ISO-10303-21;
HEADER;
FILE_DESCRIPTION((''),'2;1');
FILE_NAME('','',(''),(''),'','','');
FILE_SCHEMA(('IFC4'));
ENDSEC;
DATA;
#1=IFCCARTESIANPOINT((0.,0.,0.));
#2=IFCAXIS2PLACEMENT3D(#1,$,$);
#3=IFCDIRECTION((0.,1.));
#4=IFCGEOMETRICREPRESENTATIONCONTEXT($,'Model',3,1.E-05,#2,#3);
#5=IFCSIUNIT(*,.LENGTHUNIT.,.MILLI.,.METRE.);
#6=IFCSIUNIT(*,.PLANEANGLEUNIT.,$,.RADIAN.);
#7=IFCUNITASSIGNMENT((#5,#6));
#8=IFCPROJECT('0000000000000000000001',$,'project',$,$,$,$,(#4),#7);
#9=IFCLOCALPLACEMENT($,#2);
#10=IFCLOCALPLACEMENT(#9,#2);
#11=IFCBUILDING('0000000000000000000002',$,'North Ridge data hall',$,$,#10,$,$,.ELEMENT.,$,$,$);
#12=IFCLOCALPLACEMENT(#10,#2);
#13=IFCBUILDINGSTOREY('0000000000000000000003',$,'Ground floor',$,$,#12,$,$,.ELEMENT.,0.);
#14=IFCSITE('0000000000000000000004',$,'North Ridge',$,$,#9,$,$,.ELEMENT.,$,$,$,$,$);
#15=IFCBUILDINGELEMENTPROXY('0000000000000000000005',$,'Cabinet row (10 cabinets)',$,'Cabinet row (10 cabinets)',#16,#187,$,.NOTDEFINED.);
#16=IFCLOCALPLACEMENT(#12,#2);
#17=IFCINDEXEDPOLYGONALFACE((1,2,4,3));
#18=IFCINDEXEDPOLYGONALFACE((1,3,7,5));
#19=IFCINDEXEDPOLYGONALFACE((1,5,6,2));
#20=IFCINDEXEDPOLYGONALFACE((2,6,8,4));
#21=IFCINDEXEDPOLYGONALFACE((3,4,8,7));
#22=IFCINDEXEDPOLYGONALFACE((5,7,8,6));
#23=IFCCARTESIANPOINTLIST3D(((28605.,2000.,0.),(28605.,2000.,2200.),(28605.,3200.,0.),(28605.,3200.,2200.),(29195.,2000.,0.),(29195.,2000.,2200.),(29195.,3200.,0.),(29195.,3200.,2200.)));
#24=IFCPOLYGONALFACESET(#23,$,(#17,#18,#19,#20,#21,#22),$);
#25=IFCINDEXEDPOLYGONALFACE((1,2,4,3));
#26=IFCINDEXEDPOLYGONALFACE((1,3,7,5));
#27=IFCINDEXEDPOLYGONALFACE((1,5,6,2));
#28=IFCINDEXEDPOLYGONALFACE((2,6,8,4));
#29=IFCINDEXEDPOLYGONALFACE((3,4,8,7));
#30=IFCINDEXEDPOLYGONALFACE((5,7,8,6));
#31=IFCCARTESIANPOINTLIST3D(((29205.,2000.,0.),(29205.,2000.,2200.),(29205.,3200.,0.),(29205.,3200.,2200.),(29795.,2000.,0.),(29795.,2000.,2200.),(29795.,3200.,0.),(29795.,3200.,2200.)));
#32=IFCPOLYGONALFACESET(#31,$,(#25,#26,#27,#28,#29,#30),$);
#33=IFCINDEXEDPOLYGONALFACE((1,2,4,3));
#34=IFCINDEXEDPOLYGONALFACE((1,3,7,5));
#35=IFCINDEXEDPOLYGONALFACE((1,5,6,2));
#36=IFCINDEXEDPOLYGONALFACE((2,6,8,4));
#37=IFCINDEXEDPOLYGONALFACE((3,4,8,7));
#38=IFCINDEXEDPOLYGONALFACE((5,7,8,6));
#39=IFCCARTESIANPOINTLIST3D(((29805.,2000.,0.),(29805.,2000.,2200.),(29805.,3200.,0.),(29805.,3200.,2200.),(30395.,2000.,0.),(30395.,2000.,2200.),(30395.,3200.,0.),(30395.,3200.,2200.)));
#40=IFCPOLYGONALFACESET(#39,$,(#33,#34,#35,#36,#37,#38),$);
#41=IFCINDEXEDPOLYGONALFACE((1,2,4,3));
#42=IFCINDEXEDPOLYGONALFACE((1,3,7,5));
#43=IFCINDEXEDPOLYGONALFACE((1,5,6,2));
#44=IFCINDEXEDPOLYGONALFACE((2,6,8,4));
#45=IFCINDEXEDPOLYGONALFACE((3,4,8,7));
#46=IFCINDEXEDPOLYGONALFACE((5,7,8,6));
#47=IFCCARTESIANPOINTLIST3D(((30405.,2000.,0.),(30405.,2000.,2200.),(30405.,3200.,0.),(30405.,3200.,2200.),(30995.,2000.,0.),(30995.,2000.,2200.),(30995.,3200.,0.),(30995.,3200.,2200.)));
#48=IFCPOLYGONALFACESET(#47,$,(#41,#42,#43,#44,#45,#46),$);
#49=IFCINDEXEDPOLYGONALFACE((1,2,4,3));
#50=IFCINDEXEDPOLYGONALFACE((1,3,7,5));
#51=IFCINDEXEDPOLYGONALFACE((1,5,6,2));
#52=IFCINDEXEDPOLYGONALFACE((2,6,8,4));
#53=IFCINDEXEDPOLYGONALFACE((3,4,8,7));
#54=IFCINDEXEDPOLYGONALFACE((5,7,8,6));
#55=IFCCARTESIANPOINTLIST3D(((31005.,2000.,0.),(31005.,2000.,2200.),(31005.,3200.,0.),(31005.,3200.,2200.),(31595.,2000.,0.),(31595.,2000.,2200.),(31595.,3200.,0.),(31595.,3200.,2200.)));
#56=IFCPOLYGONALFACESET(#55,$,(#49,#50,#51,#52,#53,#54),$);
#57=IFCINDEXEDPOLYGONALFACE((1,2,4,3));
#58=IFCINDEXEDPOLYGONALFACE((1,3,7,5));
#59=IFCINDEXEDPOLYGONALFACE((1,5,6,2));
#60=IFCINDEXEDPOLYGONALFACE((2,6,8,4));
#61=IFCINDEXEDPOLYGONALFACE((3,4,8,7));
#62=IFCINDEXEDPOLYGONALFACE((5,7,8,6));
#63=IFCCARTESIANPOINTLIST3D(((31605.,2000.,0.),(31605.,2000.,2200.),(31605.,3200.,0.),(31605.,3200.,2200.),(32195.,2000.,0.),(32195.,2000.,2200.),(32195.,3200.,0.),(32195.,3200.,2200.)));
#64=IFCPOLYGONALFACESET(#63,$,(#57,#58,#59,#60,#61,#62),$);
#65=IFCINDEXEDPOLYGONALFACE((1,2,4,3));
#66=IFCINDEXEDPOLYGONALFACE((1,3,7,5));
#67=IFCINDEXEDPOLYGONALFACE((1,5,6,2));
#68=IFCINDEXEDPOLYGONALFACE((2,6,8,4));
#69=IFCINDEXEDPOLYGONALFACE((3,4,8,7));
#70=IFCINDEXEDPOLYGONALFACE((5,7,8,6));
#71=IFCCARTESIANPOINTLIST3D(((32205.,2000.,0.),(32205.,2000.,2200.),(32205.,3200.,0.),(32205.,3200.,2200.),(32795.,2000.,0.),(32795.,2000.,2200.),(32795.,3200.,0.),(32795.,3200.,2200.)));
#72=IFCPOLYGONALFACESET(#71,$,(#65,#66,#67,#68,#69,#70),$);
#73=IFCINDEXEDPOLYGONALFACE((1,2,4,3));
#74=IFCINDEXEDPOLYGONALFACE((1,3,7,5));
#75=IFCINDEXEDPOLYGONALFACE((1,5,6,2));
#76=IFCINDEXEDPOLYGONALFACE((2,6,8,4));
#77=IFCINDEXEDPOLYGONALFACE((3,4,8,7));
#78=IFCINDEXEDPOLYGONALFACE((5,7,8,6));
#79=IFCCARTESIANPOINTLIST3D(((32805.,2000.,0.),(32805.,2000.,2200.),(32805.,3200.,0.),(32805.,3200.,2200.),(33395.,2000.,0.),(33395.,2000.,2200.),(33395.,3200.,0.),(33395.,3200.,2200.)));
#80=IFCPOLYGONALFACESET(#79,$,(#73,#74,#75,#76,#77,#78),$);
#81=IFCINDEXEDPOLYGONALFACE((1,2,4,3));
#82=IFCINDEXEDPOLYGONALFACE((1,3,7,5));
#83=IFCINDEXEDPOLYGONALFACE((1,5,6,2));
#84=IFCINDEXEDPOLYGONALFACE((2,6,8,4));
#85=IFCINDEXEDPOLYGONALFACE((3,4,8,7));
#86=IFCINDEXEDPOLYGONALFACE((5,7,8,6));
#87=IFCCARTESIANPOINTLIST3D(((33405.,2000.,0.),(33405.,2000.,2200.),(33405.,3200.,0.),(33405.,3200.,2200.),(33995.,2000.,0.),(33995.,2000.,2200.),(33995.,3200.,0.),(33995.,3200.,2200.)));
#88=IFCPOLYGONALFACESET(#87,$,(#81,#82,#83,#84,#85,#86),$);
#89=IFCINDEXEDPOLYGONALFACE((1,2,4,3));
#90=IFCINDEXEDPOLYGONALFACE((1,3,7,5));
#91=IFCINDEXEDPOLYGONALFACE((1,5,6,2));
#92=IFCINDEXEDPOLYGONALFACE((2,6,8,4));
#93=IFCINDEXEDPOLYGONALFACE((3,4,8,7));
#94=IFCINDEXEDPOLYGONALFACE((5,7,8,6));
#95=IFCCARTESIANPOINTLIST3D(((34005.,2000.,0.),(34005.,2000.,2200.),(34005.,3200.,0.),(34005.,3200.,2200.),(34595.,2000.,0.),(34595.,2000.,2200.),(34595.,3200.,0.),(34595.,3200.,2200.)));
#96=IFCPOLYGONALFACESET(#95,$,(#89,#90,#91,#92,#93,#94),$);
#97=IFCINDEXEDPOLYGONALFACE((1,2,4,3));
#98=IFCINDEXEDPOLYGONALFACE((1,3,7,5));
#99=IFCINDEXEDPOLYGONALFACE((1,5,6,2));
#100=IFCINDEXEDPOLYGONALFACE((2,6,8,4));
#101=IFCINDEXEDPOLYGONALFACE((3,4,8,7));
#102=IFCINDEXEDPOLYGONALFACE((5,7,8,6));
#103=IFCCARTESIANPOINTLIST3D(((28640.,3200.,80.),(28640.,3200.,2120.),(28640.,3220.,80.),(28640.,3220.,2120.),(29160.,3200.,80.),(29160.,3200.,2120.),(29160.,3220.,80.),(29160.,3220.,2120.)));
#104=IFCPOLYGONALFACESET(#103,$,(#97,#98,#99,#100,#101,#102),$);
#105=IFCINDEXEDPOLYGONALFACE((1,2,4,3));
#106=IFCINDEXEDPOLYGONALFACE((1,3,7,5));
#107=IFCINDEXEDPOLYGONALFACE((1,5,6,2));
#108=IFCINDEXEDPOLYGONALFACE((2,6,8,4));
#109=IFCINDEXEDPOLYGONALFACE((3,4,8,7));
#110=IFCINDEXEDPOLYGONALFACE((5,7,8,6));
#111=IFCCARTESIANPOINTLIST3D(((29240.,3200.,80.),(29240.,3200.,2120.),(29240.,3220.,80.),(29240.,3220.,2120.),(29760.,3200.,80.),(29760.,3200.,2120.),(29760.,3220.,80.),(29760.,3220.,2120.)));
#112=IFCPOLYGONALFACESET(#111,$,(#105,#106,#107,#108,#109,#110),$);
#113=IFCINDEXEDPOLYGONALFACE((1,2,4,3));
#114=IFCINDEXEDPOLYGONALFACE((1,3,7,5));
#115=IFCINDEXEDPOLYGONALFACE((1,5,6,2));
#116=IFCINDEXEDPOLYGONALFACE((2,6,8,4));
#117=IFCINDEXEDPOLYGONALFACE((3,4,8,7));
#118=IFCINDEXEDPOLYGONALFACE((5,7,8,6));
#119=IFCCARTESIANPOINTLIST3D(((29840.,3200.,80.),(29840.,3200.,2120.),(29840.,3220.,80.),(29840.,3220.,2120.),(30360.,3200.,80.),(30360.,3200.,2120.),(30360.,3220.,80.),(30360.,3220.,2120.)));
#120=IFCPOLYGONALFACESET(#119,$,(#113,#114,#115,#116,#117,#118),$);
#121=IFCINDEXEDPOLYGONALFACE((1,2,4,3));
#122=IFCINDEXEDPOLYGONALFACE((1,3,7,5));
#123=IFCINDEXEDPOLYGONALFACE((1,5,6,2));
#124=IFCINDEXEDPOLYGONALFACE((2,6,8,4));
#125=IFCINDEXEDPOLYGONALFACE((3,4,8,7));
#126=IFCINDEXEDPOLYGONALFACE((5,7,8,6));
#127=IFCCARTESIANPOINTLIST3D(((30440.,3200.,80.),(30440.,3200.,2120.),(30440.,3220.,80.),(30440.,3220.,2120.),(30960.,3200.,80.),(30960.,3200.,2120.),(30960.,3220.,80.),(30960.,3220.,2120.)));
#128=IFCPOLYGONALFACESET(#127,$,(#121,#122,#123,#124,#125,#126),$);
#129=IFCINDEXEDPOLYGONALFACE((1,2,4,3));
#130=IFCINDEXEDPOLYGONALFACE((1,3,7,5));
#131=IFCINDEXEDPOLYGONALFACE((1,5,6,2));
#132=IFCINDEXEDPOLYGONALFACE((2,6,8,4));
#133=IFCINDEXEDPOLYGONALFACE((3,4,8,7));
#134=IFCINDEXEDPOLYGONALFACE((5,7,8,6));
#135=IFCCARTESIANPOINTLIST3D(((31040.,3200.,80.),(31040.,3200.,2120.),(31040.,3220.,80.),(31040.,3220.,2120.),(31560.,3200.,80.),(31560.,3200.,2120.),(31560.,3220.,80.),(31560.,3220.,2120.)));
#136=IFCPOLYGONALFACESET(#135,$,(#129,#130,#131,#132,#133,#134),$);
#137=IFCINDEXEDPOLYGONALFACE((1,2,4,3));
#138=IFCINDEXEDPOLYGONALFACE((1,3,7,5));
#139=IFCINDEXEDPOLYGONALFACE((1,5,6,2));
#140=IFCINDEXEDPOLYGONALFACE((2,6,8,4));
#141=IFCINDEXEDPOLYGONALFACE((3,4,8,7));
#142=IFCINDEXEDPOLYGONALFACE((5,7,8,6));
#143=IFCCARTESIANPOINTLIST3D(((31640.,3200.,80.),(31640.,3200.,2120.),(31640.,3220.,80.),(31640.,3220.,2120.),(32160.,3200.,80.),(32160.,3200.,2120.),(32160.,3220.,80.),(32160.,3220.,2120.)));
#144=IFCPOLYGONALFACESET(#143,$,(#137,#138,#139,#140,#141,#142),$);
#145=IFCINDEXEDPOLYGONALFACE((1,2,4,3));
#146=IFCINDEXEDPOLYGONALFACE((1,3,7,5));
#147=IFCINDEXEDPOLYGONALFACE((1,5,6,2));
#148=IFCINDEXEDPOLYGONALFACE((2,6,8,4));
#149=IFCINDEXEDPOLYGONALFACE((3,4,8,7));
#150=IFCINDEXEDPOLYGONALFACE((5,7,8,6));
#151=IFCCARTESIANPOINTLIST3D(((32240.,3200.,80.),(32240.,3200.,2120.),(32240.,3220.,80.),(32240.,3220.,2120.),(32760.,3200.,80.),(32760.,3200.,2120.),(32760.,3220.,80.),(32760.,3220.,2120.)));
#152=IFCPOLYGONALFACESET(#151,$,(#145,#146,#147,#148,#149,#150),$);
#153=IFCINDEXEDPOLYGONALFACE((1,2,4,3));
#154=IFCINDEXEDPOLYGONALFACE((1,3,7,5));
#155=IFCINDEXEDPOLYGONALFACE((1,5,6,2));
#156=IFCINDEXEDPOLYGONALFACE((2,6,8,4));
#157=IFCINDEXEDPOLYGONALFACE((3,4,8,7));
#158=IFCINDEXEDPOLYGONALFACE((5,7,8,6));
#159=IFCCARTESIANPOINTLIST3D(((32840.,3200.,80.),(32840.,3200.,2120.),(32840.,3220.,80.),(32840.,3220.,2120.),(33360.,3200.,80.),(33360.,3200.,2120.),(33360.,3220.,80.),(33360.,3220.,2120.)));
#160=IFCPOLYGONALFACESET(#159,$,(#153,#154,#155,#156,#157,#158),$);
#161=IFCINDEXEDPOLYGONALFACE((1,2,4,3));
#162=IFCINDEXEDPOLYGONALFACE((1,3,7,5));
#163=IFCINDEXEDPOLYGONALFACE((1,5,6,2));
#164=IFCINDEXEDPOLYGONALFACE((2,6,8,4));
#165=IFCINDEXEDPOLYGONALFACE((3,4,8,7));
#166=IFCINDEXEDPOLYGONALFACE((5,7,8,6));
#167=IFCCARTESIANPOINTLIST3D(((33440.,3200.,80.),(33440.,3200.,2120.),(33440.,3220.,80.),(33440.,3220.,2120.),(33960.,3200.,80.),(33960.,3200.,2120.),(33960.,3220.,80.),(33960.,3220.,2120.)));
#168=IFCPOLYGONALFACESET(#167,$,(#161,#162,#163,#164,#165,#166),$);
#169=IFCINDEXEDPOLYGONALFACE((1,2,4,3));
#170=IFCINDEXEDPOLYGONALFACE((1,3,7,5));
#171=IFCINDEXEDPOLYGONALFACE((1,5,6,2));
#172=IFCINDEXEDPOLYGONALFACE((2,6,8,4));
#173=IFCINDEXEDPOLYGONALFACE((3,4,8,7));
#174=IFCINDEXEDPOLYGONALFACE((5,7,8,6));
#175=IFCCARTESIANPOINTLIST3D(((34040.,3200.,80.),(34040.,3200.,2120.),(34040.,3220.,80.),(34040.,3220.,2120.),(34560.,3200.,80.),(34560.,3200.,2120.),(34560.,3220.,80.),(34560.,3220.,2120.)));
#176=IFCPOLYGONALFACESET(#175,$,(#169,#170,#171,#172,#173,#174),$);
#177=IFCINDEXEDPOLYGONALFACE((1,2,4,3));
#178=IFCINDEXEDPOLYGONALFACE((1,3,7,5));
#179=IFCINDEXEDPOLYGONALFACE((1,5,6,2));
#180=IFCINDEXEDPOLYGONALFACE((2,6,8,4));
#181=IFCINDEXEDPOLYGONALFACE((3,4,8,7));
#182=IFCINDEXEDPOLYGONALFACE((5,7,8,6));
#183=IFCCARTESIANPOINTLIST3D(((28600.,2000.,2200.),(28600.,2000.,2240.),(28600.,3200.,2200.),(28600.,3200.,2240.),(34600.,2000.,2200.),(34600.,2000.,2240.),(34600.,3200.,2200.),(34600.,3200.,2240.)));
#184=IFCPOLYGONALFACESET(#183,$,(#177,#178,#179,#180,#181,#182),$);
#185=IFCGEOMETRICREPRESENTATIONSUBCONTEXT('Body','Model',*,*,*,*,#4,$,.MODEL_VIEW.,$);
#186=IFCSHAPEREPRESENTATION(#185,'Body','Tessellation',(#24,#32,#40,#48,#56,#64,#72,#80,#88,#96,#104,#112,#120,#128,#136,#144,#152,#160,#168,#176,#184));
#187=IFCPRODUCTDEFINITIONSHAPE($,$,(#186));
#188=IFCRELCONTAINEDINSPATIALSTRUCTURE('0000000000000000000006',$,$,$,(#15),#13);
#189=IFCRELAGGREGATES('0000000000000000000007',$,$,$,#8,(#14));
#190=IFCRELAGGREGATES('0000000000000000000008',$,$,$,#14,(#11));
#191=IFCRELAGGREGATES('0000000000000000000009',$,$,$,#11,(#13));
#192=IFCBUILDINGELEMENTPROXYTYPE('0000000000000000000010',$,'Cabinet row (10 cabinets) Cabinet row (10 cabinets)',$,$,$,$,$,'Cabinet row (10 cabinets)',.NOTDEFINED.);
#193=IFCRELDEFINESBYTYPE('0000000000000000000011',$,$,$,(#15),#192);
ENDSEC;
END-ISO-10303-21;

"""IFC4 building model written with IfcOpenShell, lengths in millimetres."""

from ifc_helpers import new_model, si_unit, direction, frame, origin, place, context, subcontext, project, spatial, polyline, outline, extrude, source, transform, mapped, type_object, type_shapes, element, save


model = new_model("IFC4")

# Units and contexts
model_context = context("Model", 3, precision=1e-05, world=origin(), true_north=direction((0.0, 1.0)))
body_context = subcontext(model_context, "Body", "Model", "MODEL_VIEW")
ifc_project = project(units=[si_unit("LENGTHUNIT", "METRE", prefix="MILLI"), si_unit("PLANEANGLEUNIT", "RADIAN")], contexts=[model_context])

# Site, building, storey
site_placement = place(None, origin())
site = spatial("IfcSite", under=ifc_project, at=site_placement, Name="North Ridge", CompositionType="ELEMENT")
building_placement = place(site_placement, origin())
building = spatial("IfcBuilding", under=site, at=building_placement, Name="North Ridge data hall", CompositionType="ELEMENT")
storey_placement = place(building_placement, origin())
storey = spatial("IfcBuildingStorey", under=building, at=storey_placement, Name="Ground floor", CompositionType="ELEMENT", Elevation=0.0)

# Building element proxy
building_element_proxy_type_1 = type_object("IfcBuildingElementProxyType", Name="Cabinet row (10 cabinets) Cabinet row (10 cabinets)", ElementType="Cabinet row (10 cabinets)", PredefinedType="NOTDEFINED")
shared_shape_1 = source(origin(), body_context, "Body", "SweptSolid", [
    extrude(outline(polyline([(5.0, 0.0), (595.0, 0.0), (595.0, 1200.0), (5.0, 1200.0), (5.0, 0.0)])), origin(), (0.0, 0.0, 1.0), 2200.0),
    extrude(outline(polyline([(605.0, 0.0), (1195.0, 0.0), (1195.0, 1200.0), (605.0, 1200.0), (605.0, 0.0)])), origin(), (0.0, 0.0, 1.0), 2200.0),
    extrude(outline(polyline([(1205.0, 0.0), (1795.0, 0.0), (1795.0, 1200.0), (1205.0, 1200.0), (1205.0, 0.0)])), origin(), (0.0, 0.0, 1.0), 2200.0),
    extrude(outline(polyline([(1805.0, 0.0), (2395.0, 0.0), (2395.0, 1200.0), (1805.0, 1200.0), (1805.0, 0.0)])), origin(), (0.0, 0.0, 1.0), 2200.0),
    extrude(outline(polyline([(2405.0, 0.0), (2995.0, 0.0), (2995.0, 1200.0), (2405.0, 1200.0), (2405.0, 0.0)])), origin(), (0.0, 0.0, 1.0), 2200.0),
    extrude(outline(polyline([(3005.0, 0.0), (3595.0, 0.0), (3595.0, 1200.0), (3005.0, 1200.0), (3005.0, 0.0)])), origin(), (0.0, 0.0, 1.0), 2200.0),
    extrude(outline(polyline([(3605.0, 0.0), (4195.0, 0.0), (4195.0, 1200.0), (3605.0, 1200.0), (3605.0, 0.0)])), origin(), (0.0, 0.0, 1.0), 2200.0),
    extrude(outline(polyline([(4205.0, 0.0), (4795.0, 0.0), (4795.0, 1200.0), (4205.0, 1200.0), (4205.0, 0.0)])), origin(), (0.0, 0.0, 1.0), 2200.0),
    extrude(outline(polyline([(4805.0, 0.0), (5395.0, 0.0), (5395.0, 1200.0), (4805.0, 1200.0), (4805.0, 0.0)])), origin(), (0.0, 0.0, 1.0), 2200.0),
    extrude(outline(polyline([(5405.0, 0.0), (5995.0, 0.0), (5995.0, 1200.0), (5405.0, 1200.0), (5405.0, 0.0)])), origin(), (0.0, 0.0, 1.0), 2200.0),
    extrude(outline(polyline([(40.0, 1200.0), (560.0, 1200.0), (560.0, 1220.0), (40.0, 1220.0), (40.0, 1200.0)])), frame((0.0, 0.0, 80.0)), (0.0, 0.0, 1.0), 2040.0),
    extrude(outline(polyline([(640.0, 1200.0), (1160.0, 1200.0), (1160.0, 1220.0), (640.0, 1220.0), (640.0, 1200.0)])), frame((0.0, 0.0, 80.0)), (0.0, 0.0, 1.0), 2040.0),
    extrude(outline(polyline([(1240.0, 1200.0), (1760.0, 1200.0), (1760.0, 1220.0), (1240.0, 1220.0), (1240.0, 1200.0)])), frame((0.0, 0.0, 80.0)), (0.0, 0.0, 1.0), 2040.0),
    extrude(outline(polyline([(1840.0, 1200.0), (2360.0, 1200.0), (2360.0, 1220.0), (1840.0, 1220.0), (1840.0, 1200.0)])), frame((0.0, 0.0, 80.0)), (0.0, 0.0, 1.0), 2040.0),
    extrude(outline(polyline([(2440.0, 1200.0), (2960.0, 1200.0), (2960.0, 1220.0), (2440.0, 1220.0), (2440.0, 1200.0)])), frame((0.0, 0.0, 80.0)), (0.0, 0.0, 1.0), 2040.0),
    extrude(outline(polyline([(3040.0, 1200.0), (3560.0, 1200.0), (3560.0, 1220.0), (3040.0, 1220.0), (3040.0, 1200.0)])), frame((0.0, 0.0, 80.0)), (0.0, 0.0, 1.0), 2040.0),
    extrude(outline(polyline([(3640.0, 1200.0), (4160.0, 1200.0), (4160.0, 1220.0), (3640.0, 1220.0), (3640.0, 1200.0)])), frame((0.0, 0.0, 80.0)), (0.0, 0.0, 1.0), 2040.0),
    extrude(outline(polyline([(4240.0, 1200.0), (4760.0, 1200.0), (4760.0, 1220.0), (4240.0, 1220.0), (4240.0, 1200.0)])), frame((0.0, 0.0, 80.0)), (0.0, 0.0, 1.0), 2040.0),
    extrude(outline(polyline([(4840.0, 1200.0), (5360.0, 1200.0), (5360.0, 1220.0), (4840.0, 1220.0), (4840.0, 1200.0)])), frame((0.0, 0.0, 80.0)), (0.0, 0.0, 1.0), 2040.0),
    extrude(outline(polyline([(5440.0, 1200.0), (5960.0, 1200.0), (5960.0, 1220.0), (5440.0, 1220.0), (5440.0, 1200.0)])), frame((0.0, 0.0, 80.0)), (0.0, 0.0, 1.0), 2040.0),
    extrude(outline(polyline([(0.0, 0.0), (6000.0, 0.0), (6000.0, 1200.0), (0.0, 1200.0), (0.0, 0.0)])), frame((0.0, 0.0, 2200.0)), (0.0, 0.0, 1.0), 40.0),
])
type_shapes(building_element_proxy_type_1, [shared_shape_1])
for number, where, z_axis, x_axis, name in (
    (1, (28600.0, 2000.0, 0.0), (0.0, 0.0, 1.0), (1.0, 0.0, 0.0), "Cabinet row (10 cabinets)"),
):
    element("IfcBuildingElementProxy", number, at=place(storey_placement, frame(where, z_axis=z_axis, x_axis=x_axis)), inside=storey, type_object=building_element_proxy_type_1, Name=name, ObjectType="Cabinet row (10 cabinets)", PredefinedType="NOTDEFINED", context=body_context, shape_type="MappedRepresentation", body=[
        mapped(shared_shape_1, transform((0.0, 0.0, 0.0))),
    ])

save(model, "model.ifc")
